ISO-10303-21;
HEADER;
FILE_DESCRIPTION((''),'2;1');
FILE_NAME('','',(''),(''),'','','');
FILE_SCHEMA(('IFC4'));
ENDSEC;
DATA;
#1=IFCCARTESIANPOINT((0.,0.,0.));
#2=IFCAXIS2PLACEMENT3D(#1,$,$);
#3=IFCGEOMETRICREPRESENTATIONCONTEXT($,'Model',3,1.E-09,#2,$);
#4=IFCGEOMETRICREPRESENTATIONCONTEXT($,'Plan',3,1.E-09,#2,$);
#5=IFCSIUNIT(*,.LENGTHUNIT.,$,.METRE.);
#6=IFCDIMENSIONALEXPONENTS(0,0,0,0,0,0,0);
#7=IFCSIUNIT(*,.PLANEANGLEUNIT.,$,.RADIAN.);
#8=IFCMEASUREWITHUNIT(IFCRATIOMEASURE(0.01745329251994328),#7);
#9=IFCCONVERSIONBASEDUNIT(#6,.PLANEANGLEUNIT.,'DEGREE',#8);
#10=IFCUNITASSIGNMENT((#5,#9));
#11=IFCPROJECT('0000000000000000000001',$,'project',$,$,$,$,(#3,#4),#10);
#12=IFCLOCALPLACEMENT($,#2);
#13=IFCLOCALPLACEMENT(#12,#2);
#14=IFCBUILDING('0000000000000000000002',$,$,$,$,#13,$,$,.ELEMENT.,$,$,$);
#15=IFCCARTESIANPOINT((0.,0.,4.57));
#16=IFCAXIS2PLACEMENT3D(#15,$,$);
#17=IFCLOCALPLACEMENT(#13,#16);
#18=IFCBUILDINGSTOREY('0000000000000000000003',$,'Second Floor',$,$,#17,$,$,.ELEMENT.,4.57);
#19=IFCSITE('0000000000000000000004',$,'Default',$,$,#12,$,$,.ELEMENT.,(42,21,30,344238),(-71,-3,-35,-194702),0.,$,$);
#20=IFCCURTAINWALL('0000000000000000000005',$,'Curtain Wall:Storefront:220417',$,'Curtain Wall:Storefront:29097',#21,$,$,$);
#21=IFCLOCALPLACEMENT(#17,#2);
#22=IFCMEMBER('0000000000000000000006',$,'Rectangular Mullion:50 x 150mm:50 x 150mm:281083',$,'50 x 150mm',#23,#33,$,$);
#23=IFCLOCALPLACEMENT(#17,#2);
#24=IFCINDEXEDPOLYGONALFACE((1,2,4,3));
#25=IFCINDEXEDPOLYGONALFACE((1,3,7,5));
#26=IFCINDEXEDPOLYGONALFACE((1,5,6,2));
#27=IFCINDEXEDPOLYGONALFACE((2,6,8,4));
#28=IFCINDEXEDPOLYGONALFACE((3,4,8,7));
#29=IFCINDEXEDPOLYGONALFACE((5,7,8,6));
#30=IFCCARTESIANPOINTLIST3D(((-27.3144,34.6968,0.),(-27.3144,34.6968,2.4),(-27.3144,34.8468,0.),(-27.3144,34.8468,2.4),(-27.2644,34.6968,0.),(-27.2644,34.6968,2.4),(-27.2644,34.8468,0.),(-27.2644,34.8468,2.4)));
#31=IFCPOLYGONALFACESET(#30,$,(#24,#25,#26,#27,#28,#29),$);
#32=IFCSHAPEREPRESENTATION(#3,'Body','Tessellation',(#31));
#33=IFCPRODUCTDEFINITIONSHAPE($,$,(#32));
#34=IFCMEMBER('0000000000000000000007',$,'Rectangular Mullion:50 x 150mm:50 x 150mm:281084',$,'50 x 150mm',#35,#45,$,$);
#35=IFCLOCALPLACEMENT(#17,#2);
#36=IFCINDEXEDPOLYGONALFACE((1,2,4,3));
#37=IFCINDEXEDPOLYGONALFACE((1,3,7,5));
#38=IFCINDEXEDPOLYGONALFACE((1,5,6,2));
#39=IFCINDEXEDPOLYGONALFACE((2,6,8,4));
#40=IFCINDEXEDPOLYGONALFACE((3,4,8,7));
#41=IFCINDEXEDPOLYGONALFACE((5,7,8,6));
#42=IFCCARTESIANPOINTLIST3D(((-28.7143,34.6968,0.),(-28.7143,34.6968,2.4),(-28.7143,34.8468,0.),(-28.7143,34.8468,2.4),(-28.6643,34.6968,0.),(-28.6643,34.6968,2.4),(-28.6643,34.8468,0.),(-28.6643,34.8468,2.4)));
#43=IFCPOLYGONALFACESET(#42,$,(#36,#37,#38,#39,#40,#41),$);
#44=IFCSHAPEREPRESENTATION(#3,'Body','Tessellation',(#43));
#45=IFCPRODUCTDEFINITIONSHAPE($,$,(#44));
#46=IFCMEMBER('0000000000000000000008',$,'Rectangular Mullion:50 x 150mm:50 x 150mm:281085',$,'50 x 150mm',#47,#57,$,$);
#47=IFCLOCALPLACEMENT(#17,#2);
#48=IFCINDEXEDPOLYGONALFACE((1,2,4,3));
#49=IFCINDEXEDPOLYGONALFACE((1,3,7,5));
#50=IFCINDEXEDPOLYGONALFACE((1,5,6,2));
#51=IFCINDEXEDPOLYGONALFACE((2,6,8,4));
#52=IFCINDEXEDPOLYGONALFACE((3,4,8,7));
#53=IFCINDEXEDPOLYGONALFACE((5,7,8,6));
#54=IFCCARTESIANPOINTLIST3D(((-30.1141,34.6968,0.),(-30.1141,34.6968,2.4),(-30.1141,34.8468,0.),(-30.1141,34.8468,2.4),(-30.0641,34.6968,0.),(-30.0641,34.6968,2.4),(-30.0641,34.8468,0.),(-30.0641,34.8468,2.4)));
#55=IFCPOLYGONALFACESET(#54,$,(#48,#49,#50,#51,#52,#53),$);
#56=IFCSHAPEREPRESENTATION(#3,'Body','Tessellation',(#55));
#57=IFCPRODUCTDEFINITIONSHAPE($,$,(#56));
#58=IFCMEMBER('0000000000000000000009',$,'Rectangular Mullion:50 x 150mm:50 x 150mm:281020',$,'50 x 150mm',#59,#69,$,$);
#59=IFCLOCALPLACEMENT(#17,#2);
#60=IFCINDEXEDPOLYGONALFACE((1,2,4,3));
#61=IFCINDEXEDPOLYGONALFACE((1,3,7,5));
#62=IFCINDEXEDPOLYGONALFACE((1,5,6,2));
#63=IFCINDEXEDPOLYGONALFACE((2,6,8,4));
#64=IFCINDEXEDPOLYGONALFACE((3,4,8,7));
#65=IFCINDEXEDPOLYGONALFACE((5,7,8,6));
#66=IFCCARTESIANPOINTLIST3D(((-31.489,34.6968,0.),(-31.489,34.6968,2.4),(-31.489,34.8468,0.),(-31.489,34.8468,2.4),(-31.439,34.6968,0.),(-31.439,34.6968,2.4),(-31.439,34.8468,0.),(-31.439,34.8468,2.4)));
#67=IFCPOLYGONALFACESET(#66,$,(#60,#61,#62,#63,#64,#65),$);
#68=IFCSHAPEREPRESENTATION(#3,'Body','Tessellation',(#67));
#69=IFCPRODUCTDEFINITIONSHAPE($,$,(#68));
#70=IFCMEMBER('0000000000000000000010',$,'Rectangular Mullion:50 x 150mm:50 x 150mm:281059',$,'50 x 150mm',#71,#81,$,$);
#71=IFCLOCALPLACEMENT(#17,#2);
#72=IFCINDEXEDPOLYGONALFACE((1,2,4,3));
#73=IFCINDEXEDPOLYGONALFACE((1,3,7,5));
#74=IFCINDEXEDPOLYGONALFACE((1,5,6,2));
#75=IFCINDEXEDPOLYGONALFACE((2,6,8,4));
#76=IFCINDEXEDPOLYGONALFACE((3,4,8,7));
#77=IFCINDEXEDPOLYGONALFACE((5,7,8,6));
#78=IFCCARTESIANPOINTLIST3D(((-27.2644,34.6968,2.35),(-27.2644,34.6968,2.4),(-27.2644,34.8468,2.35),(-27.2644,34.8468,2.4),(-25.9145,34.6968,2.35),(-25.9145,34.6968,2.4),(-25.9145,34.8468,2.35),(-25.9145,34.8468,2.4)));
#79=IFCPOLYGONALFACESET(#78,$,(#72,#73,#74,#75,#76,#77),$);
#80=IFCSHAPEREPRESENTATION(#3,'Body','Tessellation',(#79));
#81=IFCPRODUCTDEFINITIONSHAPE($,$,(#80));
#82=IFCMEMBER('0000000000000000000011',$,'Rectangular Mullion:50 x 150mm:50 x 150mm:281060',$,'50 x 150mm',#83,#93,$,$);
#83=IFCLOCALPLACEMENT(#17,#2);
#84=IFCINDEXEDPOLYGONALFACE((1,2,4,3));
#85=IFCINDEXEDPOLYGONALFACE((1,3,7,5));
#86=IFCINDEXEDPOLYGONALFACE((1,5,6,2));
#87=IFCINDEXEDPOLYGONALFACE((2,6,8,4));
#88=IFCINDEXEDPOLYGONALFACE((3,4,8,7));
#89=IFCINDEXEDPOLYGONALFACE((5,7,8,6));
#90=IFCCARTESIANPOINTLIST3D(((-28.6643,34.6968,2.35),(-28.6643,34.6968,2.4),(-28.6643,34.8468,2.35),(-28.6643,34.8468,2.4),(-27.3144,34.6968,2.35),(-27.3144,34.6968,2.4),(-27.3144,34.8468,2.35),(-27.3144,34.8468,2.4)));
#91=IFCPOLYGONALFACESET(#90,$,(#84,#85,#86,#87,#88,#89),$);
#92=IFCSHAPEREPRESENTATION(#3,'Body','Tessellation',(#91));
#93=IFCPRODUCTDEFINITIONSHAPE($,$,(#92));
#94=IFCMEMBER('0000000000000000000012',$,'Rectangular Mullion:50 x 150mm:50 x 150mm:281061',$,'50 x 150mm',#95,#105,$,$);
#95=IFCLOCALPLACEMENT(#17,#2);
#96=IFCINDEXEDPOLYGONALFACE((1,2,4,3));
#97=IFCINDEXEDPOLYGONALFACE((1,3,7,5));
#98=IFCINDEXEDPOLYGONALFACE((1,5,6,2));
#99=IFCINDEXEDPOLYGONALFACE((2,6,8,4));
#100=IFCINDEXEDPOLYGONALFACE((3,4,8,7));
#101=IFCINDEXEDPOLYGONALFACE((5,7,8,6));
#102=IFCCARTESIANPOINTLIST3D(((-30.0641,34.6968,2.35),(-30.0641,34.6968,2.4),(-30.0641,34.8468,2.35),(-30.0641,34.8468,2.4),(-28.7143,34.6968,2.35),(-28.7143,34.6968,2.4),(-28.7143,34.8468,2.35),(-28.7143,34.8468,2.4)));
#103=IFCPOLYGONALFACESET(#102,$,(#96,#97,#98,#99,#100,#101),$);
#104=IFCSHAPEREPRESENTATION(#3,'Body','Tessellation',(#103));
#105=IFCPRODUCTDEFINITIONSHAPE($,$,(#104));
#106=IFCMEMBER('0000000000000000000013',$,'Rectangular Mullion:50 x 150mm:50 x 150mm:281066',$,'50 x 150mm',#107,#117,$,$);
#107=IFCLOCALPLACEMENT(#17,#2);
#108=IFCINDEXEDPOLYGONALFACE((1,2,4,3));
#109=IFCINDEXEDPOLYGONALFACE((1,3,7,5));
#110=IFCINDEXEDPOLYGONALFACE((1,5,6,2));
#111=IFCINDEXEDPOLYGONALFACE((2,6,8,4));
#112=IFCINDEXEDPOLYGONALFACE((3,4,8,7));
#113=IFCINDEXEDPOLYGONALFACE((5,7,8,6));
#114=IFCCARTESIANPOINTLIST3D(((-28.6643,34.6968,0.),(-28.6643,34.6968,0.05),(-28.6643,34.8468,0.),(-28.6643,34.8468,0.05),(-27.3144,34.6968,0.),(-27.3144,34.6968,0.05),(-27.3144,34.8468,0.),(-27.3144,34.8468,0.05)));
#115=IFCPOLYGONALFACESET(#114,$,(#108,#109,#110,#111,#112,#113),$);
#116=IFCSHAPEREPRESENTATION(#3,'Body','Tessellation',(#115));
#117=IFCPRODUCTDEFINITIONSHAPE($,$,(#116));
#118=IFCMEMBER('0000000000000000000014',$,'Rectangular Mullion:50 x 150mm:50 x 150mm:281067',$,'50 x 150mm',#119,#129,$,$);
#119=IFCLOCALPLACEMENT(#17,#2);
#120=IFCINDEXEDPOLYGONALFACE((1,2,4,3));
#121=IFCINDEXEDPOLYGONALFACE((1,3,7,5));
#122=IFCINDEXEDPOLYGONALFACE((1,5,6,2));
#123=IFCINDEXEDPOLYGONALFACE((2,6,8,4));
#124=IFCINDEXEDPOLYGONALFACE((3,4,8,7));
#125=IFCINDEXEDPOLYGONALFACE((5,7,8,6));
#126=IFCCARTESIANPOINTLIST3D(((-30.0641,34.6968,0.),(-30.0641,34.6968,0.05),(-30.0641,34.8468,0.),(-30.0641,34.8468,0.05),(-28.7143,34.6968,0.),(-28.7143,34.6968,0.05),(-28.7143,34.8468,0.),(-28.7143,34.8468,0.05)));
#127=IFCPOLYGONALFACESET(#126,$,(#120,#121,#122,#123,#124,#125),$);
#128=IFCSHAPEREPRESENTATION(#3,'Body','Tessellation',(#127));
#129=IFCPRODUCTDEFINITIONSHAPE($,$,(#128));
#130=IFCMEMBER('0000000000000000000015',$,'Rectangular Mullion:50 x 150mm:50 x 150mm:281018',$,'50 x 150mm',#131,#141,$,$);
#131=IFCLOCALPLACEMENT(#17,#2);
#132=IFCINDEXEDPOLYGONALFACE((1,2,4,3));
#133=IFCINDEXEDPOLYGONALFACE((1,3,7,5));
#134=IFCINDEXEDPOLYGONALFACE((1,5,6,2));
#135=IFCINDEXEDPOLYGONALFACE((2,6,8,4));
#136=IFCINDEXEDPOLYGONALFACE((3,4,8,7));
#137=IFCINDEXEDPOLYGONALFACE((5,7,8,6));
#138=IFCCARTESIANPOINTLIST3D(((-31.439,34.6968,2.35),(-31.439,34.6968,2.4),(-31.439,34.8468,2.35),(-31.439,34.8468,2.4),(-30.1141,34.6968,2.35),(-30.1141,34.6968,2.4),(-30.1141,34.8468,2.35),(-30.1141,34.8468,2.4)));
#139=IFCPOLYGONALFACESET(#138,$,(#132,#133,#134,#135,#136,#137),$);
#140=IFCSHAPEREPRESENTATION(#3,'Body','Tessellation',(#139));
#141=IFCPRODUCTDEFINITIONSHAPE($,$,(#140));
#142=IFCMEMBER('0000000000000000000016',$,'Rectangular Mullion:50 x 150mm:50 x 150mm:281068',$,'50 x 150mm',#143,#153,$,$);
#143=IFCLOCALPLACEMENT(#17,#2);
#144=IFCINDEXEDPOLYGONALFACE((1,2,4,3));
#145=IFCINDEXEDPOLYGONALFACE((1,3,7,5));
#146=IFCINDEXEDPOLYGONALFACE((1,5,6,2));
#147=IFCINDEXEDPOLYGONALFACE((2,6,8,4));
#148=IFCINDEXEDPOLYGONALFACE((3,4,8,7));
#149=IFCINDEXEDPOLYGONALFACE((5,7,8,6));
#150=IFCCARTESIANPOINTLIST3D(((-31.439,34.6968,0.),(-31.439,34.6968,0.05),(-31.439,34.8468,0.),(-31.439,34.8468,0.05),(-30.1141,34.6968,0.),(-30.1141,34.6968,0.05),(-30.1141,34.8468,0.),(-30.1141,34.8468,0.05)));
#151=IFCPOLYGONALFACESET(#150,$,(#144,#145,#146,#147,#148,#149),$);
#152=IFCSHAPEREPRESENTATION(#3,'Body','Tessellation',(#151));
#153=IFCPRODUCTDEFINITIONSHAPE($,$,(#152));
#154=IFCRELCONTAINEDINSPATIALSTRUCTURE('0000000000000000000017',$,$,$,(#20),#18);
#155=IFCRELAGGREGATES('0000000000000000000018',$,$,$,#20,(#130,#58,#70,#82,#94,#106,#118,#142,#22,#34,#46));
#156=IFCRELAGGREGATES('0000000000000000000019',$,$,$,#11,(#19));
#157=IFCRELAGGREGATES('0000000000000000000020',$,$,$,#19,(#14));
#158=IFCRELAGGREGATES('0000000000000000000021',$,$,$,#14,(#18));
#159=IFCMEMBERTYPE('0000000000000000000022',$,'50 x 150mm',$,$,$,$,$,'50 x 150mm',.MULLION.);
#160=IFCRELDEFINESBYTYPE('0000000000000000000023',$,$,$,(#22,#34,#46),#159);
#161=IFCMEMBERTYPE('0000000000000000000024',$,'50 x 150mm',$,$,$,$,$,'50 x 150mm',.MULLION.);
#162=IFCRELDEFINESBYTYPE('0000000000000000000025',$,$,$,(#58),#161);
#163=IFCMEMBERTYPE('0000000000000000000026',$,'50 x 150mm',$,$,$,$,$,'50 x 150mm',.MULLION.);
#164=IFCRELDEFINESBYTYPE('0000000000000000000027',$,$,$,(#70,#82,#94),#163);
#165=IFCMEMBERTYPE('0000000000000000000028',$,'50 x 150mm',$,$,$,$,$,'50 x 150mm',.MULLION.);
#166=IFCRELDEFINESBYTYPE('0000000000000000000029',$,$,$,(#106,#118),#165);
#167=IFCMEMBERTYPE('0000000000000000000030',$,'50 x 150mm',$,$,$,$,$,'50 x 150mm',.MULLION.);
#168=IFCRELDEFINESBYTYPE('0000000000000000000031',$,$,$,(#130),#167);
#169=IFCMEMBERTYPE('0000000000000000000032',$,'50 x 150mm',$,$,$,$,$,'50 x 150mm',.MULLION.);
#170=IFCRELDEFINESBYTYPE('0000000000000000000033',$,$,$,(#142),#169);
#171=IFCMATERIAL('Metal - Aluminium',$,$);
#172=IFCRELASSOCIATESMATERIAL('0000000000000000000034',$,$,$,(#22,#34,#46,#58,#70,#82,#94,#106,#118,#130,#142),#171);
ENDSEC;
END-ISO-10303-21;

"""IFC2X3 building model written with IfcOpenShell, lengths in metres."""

from ifc_helpers import new_model, entity, si_unit, converted_unit, frame, origin, origin_2d_with_axis, place, context, project, spatial, rectangle, extrude, source, transform, mapped, material, type_object, type_shapes, element, aggregate, save


model = new_model("IFC2X3")

# Units and contexts
model_context = context("Model", 3, precision=1e-09, world=origin())
plan_context = context("Plan", 3, precision=1e-09, world=origin())
ifc_project = project(units=[si_unit("LENGTHUNIT", "METRE"), converted_unit("PLANEANGLEUNIT", "DEGREE", entity("IfcRatioMeasure", 0.01745329251994328), si_unit("PLANEANGLEUNIT", "RADIAN"), dimensions=[0, 0, 0, 0, 0, 0, 0])], contexts=[model_context, plan_context])

# Site, building, storey
site_placement = place(None, origin())
site = spatial("IfcSite", under=ifc_project, at=site_placement, Name="Default", CompositionType="ELEMENT", RefLatitude=(42, 21, 30, 344238), RefLongitude=(-71, -3, -35, -194702), RefElevation=0.0)
building_placement = place(site_placement, origin())
building = spatial("IfcBuilding", under=site, at=building_placement, CompositionType="ELEMENT")
storey_placement = place(building_placement, frame((0.0, 0.0, 4.57)))
storey = spatial("IfcBuildingStorey", under=building, at=storey_placement, Name="Second Floor", CompositionType="ELEMENT", Elevation=4.57)

# Curtain wall, members
curtain_wall_placement = place(storey_placement, origin())
curtain_wall = element("IfcCurtainWall", 1, at=curtain_wall_placement, inside=storey, Name="Curtain Wall:Storefront:220417", ObjectType="Curtain Wall:Storefront:29097")
ifc_material_1 = material(Name="Metal - Aluminium")
member_type_1 = type_object("IfcMemberType", Name="50 x 150mm", ElementType="50 x 150mm", PredefinedType="MULLION")
shared_shape_1 = source(origin(), model_context, "Body", "SweptSolid", [
    extrude(rectangle(XDim=0.05, YDim=0.15, at=origin_2d_with_axis()), frame((0.0, 0.0, -2.4), z_axis=(0.0, 0.0, 1.0), x_axis=(-1.0, 0.0, 0.0)), (0.0, 0.0, 1.0), 2.4),
])
type_shapes(member_type_1, [shared_shape_1])
member_1_placement = place(storey_placement, frame((-27.2894, 34.7718, 0.0), z_axis=(0.0, 0.0, -1.0), x_axis=(-1.0, 0.0, 0.0)))
member_1 = element("IfcMember", 2, at=member_1_placement, type_object=member_type_1, material=ifc_material_1, Name="Rectangular Mullion:50 x 150mm:50 x 150mm:281083", ObjectType="50 x 150mm", context=model_context, shape_type="MappedRepresentation", body=[
    mapped(shared_shape_1, transform((0.0, 0.0, 0.0), scale=1.0)),
])
member_2_placement = place(storey_placement, frame((-28.6893, 34.7718, 0.0), z_axis=(0.0, 0.0, -1.0), x_axis=(-1.0, 0.0, 0.0)))
member_2 = element("IfcMember", 3, at=member_2_placement, type_object=member_type_1, material=ifc_material_1, Name="Rectangular Mullion:50 x 150mm:50 x 150mm:281084", ObjectType="50 x 150mm", context=model_context, shape_type="MappedRepresentation", body=[
    mapped(shared_shape_1, transform((0.0, 0.0, 0.0), scale=1.0)),
])
member_3_placement = place(storey_placement, frame((-30.0891, 34.7718, 0.0), z_axis=(0.0, 0.0, -1.0), x_axis=(-1.0, 0.0, 0.0)))
member_3 = element("IfcMember", 4, at=member_3_placement, type_object=member_type_1, material=ifc_material_1, Name="Rectangular Mullion:50 x 150mm:50 x 150mm:281085", ObjectType="50 x 150mm", context=model_context, shape_type="MappedRepresentation", body=[
    mapped(shared_shape_1, transform((0.0, 0.0, 0.0), scale=1.0)),
])
member_type_2 = type_object("IfcMemberType", Name="50 x 150mm", ElementType="50 x 150mm", PredefinedType="MULLION")
shared_shape_2 = source(origin(), model_context, "Body", "SweptSolid", [
    extrude(rectangle(XDim=0.05, YDim=0.15, at=origin_2d_with_axis()), frame((-0.025, 0.0, -2.4), z_axis=(0.0, 0.0, 1.0), x_axis=(-1.0, 0.0, 0.0)), (0.0, 0.0, 1.0), 2.4),
])
type_shapes(member_type_2, [shared_shape_2])
member_4_placement = place(storey_placement, frame((-31.489, 34.7718, 0.0), z_axis=(0.0, 0.0, -1.0), x_axis=(-1.0, 0.0, 0.0)))
member_4 = element("IfcMember", 5, at=member_4_placement, type_object=member_type_2, material=ifc_material_1, Name="Rectangular Mullion:50 x 150mm:50 x 150mm:281020", ObjectType="50 x 150mm", context=model_context, shape_type="MappedRepresentation", body=[
    mapped(shared_shape_2, transform((0.0, 0.0, 0.0), scale=1.0)),
])
member_type_3 = type_object("IfcMemberType", Name="50 x 150mm", ElementType="50 x 150mm", PredefinedType="MULLION")
shared_shape_3 = source(origin(), model_context, "Body", "SweptSolid", [
    extrude(rectangle(XDim=0.05, YDim=0.15, at=origin_2d_with_axis()), frame((-0.025, 0.0, -1.3499), z_axis=(0.0, 0.0, 1.0), x_axis=(-1.0, 0.0, 0.0)), (0.0, 0.0, 1.0), 1.3499),
])
type_shapes(member_type_3, [shared_shape_3])
member_5_placement = place(storey_placement, frame((-27.2644, 34.7718, 2.4), z_axis=(-1.0, 0.0, 0.0), x_axis=(0.0, 0.0, 1.0)))
member_5 = element("IfcMember", 6, at=member_5_placement, type_object=member_type_3, material=ifc_material_1, Name="Rectangular Mullion:50 x 150mm:50 x 150mm:281059", ObjectType="50 x 150mm", context=model_context, shape_type="MappedRepresentation", body=[
    mapped(shared_shape_3, transform((0.0, 0.0, 0.0), scale=1.0)),
])
member_6_placement = place(storey_placement, frame((-28.6643, 34.7718, 2.4), z_axis=(-1.0, 0.0, 0.0), x_axis=(0.0, 0.0, 1.0)))
member_6 = element("IfcMember", 7, at=member_6_placement, type_object=member_type_3, material=ifc_material_1, Name="Rectangular Mullion:50 x 150mm:50 x 150mm:281060", ObjectType="50 x 150mm", context=model_context, shape_type="MappedRepresentation", body=[
    mapped(shared_shape_3, transform((0.0, 0.0, 0.0), scale=1.0)),
])
member_7_placement = place(storey_placement, frame((-30.0641, 34.7718, 2.4), z_axis=(-1.0, 0.0, 0.0), x_axis=(0.0, 0.0, 1.0)))
member_7 = element("IfcMember", 8, at=member_7_placement, type_object=member_type_3, material=ifc_material_1, Name="Rectangular Mullion:50 x 150mm:50 x 150mm:281061", ObjectType="50 x 150mm", context=model_context, shape_type="MappedRepresentation", body=[
    mapped(shared_shape_3, transform((0.0, 0.0, 0.0), scale=1.0)),
])
member_type_4 = type_object("IfcMemberType", Name="50 x 150mm", ElementType="50 x 150mm", PredefinedType="MULLION")
shared_shape_4 = source(origin(), model_context, "Body", "SweptSolid", [
    extrude(rectangle(XDim=0.05, YDim=0.15, at=origin_2d_with_axis()), frame((-0.025, 0.0, -1.3499), z_axis=(0.0, 0.0, 1.0), x_axis=(-1.0, 0.0, 0.0)), (0.0, 0.0, 1.0), 1.3499),
])
type_shapes(member_type_4, [shared_shape_4])
member_8_placement = place(storey_placement, frame((-27.3144, 34.7718, 0.0), z_axis=(1.0, 0.0, 0.0), x_axis=(0.0, 0.0, -1.0)))
member_8 = element("IfcMember", 9, at=member_8_placement, type_object=member_type_4, material=ifc_material_1, Name="Rectangular Mullion:50 x 150mm:50 x 150mm:281066", ObjectType="50 x 150mm", context=model_context, shape_type="MappedRepresentation", body=[
    mapped(shared_shape_4, transform((0.0, 0.0, 0.0), scale=1.0)),
])
member_9_placement = place(storey_placement, frame((-28.7143, 34.7718, 0.0), z_axis=(1.0, 0.0, 0.0), x_axis=(0.0, 0.0, -1.0)))
member_9 = element("IfcMember", 10, at=member_9_placement, type_object=member_type_4, material=ifc_material_1, Name="Rectangular Mullion:50 x 150mm:50 x 150mm:281067", ObjectType="50 x 150mm", context=model_context, shape_type="MappedRepresentation", body=[
    mapped(shared_shape_4, transform((0.0, 0.0, 0.0), scale=1.0)),
])
member_type_5 = type_object("IfcMemberType", Name="50 x 150mm", ElementType="50 x 150mm", PredefinedType="MULLION")
shared_shape_5 = source(origin(), model_context, "Body", "SweptSolid", [
    extrude(rectangle(XDim=0.05, YDim=0.15, at=origin_2d_with_axis()), frame((-0.025, 0.0, -1.3249), z_axis=(0.0, 0.0, 1.0), x_axis=(-1.0, 0.0, 0.0)), (0.0, 0.0, 1.0), 1.3249),
])
type_shapes(member_type_5, [shared_shape_5])
member_10_placement = place(storey_placement, frame((-31.439, 34.7718, 2.4), z_axis=(-1.0, 0.0, 0.0), x_axis=(0.0, 0.0, 1.0)))
member_10 = element("IfcMember", 11, at=member_10_placement, type_object=member_type_5, material=ifc_material_1, Name="Rectangular Mullion:50 x 150mm:50 x 150mm:281018", ObjectType="50 x 150mm", context=model_context, shape_type="MappedRepresentation", body=[
    mapped(shared_shape_5, transform((0.0, 0.0, 0.0), scale=1.0)),
])
member_type_6 = type_object("IfcMemberType", Name="50 x 150mm", ElementType="50 x 150mm", PredefinedType="MULLION")
shared_shape_6 = source(origin(), model_context, "Body", "SweptSolid", [
    extrude(rectangle(XDim=0.05, YDim=0.15, at=origin_2d_with_axis()), frame((-0.025, 0.0, -1.3249), z_axis=(0.0, 0.0, 1.0), x_axis=(-1.0, 0.0, 0.0)), (0.0, 0.0, 1.0), 1.3249),
])
type_shapes(member_type_6, [shared_shape_6])
member_11_placement = place(storey_placement, frame((-30.1141, 34.7718, 0.0), z_axis=(1.0, 0.0, 0.0), x_axis=(0.0, 0.0, -1.0)))
member_11 = element("IfcMember", 12, at=member_11_placement, type_object=member_type_6, material=ifc_material_1, Name="Rectangular Mullion:50 x 150mm:50 x 150mm:281068", ObjectType="50 x 150mm", context=model_context, shape_type="MappedRepresentation", body=[
    mapped(shared_shape_6, transform((0.0, 0.0, 0.0), scale=1.0)),
])
aggregate(curtain_wall, [member_10, member_4, member_5, member_6, member_7, member_8, member_9, member_11, member_1, member_2, member_3])

save(model, "model.ifc")
